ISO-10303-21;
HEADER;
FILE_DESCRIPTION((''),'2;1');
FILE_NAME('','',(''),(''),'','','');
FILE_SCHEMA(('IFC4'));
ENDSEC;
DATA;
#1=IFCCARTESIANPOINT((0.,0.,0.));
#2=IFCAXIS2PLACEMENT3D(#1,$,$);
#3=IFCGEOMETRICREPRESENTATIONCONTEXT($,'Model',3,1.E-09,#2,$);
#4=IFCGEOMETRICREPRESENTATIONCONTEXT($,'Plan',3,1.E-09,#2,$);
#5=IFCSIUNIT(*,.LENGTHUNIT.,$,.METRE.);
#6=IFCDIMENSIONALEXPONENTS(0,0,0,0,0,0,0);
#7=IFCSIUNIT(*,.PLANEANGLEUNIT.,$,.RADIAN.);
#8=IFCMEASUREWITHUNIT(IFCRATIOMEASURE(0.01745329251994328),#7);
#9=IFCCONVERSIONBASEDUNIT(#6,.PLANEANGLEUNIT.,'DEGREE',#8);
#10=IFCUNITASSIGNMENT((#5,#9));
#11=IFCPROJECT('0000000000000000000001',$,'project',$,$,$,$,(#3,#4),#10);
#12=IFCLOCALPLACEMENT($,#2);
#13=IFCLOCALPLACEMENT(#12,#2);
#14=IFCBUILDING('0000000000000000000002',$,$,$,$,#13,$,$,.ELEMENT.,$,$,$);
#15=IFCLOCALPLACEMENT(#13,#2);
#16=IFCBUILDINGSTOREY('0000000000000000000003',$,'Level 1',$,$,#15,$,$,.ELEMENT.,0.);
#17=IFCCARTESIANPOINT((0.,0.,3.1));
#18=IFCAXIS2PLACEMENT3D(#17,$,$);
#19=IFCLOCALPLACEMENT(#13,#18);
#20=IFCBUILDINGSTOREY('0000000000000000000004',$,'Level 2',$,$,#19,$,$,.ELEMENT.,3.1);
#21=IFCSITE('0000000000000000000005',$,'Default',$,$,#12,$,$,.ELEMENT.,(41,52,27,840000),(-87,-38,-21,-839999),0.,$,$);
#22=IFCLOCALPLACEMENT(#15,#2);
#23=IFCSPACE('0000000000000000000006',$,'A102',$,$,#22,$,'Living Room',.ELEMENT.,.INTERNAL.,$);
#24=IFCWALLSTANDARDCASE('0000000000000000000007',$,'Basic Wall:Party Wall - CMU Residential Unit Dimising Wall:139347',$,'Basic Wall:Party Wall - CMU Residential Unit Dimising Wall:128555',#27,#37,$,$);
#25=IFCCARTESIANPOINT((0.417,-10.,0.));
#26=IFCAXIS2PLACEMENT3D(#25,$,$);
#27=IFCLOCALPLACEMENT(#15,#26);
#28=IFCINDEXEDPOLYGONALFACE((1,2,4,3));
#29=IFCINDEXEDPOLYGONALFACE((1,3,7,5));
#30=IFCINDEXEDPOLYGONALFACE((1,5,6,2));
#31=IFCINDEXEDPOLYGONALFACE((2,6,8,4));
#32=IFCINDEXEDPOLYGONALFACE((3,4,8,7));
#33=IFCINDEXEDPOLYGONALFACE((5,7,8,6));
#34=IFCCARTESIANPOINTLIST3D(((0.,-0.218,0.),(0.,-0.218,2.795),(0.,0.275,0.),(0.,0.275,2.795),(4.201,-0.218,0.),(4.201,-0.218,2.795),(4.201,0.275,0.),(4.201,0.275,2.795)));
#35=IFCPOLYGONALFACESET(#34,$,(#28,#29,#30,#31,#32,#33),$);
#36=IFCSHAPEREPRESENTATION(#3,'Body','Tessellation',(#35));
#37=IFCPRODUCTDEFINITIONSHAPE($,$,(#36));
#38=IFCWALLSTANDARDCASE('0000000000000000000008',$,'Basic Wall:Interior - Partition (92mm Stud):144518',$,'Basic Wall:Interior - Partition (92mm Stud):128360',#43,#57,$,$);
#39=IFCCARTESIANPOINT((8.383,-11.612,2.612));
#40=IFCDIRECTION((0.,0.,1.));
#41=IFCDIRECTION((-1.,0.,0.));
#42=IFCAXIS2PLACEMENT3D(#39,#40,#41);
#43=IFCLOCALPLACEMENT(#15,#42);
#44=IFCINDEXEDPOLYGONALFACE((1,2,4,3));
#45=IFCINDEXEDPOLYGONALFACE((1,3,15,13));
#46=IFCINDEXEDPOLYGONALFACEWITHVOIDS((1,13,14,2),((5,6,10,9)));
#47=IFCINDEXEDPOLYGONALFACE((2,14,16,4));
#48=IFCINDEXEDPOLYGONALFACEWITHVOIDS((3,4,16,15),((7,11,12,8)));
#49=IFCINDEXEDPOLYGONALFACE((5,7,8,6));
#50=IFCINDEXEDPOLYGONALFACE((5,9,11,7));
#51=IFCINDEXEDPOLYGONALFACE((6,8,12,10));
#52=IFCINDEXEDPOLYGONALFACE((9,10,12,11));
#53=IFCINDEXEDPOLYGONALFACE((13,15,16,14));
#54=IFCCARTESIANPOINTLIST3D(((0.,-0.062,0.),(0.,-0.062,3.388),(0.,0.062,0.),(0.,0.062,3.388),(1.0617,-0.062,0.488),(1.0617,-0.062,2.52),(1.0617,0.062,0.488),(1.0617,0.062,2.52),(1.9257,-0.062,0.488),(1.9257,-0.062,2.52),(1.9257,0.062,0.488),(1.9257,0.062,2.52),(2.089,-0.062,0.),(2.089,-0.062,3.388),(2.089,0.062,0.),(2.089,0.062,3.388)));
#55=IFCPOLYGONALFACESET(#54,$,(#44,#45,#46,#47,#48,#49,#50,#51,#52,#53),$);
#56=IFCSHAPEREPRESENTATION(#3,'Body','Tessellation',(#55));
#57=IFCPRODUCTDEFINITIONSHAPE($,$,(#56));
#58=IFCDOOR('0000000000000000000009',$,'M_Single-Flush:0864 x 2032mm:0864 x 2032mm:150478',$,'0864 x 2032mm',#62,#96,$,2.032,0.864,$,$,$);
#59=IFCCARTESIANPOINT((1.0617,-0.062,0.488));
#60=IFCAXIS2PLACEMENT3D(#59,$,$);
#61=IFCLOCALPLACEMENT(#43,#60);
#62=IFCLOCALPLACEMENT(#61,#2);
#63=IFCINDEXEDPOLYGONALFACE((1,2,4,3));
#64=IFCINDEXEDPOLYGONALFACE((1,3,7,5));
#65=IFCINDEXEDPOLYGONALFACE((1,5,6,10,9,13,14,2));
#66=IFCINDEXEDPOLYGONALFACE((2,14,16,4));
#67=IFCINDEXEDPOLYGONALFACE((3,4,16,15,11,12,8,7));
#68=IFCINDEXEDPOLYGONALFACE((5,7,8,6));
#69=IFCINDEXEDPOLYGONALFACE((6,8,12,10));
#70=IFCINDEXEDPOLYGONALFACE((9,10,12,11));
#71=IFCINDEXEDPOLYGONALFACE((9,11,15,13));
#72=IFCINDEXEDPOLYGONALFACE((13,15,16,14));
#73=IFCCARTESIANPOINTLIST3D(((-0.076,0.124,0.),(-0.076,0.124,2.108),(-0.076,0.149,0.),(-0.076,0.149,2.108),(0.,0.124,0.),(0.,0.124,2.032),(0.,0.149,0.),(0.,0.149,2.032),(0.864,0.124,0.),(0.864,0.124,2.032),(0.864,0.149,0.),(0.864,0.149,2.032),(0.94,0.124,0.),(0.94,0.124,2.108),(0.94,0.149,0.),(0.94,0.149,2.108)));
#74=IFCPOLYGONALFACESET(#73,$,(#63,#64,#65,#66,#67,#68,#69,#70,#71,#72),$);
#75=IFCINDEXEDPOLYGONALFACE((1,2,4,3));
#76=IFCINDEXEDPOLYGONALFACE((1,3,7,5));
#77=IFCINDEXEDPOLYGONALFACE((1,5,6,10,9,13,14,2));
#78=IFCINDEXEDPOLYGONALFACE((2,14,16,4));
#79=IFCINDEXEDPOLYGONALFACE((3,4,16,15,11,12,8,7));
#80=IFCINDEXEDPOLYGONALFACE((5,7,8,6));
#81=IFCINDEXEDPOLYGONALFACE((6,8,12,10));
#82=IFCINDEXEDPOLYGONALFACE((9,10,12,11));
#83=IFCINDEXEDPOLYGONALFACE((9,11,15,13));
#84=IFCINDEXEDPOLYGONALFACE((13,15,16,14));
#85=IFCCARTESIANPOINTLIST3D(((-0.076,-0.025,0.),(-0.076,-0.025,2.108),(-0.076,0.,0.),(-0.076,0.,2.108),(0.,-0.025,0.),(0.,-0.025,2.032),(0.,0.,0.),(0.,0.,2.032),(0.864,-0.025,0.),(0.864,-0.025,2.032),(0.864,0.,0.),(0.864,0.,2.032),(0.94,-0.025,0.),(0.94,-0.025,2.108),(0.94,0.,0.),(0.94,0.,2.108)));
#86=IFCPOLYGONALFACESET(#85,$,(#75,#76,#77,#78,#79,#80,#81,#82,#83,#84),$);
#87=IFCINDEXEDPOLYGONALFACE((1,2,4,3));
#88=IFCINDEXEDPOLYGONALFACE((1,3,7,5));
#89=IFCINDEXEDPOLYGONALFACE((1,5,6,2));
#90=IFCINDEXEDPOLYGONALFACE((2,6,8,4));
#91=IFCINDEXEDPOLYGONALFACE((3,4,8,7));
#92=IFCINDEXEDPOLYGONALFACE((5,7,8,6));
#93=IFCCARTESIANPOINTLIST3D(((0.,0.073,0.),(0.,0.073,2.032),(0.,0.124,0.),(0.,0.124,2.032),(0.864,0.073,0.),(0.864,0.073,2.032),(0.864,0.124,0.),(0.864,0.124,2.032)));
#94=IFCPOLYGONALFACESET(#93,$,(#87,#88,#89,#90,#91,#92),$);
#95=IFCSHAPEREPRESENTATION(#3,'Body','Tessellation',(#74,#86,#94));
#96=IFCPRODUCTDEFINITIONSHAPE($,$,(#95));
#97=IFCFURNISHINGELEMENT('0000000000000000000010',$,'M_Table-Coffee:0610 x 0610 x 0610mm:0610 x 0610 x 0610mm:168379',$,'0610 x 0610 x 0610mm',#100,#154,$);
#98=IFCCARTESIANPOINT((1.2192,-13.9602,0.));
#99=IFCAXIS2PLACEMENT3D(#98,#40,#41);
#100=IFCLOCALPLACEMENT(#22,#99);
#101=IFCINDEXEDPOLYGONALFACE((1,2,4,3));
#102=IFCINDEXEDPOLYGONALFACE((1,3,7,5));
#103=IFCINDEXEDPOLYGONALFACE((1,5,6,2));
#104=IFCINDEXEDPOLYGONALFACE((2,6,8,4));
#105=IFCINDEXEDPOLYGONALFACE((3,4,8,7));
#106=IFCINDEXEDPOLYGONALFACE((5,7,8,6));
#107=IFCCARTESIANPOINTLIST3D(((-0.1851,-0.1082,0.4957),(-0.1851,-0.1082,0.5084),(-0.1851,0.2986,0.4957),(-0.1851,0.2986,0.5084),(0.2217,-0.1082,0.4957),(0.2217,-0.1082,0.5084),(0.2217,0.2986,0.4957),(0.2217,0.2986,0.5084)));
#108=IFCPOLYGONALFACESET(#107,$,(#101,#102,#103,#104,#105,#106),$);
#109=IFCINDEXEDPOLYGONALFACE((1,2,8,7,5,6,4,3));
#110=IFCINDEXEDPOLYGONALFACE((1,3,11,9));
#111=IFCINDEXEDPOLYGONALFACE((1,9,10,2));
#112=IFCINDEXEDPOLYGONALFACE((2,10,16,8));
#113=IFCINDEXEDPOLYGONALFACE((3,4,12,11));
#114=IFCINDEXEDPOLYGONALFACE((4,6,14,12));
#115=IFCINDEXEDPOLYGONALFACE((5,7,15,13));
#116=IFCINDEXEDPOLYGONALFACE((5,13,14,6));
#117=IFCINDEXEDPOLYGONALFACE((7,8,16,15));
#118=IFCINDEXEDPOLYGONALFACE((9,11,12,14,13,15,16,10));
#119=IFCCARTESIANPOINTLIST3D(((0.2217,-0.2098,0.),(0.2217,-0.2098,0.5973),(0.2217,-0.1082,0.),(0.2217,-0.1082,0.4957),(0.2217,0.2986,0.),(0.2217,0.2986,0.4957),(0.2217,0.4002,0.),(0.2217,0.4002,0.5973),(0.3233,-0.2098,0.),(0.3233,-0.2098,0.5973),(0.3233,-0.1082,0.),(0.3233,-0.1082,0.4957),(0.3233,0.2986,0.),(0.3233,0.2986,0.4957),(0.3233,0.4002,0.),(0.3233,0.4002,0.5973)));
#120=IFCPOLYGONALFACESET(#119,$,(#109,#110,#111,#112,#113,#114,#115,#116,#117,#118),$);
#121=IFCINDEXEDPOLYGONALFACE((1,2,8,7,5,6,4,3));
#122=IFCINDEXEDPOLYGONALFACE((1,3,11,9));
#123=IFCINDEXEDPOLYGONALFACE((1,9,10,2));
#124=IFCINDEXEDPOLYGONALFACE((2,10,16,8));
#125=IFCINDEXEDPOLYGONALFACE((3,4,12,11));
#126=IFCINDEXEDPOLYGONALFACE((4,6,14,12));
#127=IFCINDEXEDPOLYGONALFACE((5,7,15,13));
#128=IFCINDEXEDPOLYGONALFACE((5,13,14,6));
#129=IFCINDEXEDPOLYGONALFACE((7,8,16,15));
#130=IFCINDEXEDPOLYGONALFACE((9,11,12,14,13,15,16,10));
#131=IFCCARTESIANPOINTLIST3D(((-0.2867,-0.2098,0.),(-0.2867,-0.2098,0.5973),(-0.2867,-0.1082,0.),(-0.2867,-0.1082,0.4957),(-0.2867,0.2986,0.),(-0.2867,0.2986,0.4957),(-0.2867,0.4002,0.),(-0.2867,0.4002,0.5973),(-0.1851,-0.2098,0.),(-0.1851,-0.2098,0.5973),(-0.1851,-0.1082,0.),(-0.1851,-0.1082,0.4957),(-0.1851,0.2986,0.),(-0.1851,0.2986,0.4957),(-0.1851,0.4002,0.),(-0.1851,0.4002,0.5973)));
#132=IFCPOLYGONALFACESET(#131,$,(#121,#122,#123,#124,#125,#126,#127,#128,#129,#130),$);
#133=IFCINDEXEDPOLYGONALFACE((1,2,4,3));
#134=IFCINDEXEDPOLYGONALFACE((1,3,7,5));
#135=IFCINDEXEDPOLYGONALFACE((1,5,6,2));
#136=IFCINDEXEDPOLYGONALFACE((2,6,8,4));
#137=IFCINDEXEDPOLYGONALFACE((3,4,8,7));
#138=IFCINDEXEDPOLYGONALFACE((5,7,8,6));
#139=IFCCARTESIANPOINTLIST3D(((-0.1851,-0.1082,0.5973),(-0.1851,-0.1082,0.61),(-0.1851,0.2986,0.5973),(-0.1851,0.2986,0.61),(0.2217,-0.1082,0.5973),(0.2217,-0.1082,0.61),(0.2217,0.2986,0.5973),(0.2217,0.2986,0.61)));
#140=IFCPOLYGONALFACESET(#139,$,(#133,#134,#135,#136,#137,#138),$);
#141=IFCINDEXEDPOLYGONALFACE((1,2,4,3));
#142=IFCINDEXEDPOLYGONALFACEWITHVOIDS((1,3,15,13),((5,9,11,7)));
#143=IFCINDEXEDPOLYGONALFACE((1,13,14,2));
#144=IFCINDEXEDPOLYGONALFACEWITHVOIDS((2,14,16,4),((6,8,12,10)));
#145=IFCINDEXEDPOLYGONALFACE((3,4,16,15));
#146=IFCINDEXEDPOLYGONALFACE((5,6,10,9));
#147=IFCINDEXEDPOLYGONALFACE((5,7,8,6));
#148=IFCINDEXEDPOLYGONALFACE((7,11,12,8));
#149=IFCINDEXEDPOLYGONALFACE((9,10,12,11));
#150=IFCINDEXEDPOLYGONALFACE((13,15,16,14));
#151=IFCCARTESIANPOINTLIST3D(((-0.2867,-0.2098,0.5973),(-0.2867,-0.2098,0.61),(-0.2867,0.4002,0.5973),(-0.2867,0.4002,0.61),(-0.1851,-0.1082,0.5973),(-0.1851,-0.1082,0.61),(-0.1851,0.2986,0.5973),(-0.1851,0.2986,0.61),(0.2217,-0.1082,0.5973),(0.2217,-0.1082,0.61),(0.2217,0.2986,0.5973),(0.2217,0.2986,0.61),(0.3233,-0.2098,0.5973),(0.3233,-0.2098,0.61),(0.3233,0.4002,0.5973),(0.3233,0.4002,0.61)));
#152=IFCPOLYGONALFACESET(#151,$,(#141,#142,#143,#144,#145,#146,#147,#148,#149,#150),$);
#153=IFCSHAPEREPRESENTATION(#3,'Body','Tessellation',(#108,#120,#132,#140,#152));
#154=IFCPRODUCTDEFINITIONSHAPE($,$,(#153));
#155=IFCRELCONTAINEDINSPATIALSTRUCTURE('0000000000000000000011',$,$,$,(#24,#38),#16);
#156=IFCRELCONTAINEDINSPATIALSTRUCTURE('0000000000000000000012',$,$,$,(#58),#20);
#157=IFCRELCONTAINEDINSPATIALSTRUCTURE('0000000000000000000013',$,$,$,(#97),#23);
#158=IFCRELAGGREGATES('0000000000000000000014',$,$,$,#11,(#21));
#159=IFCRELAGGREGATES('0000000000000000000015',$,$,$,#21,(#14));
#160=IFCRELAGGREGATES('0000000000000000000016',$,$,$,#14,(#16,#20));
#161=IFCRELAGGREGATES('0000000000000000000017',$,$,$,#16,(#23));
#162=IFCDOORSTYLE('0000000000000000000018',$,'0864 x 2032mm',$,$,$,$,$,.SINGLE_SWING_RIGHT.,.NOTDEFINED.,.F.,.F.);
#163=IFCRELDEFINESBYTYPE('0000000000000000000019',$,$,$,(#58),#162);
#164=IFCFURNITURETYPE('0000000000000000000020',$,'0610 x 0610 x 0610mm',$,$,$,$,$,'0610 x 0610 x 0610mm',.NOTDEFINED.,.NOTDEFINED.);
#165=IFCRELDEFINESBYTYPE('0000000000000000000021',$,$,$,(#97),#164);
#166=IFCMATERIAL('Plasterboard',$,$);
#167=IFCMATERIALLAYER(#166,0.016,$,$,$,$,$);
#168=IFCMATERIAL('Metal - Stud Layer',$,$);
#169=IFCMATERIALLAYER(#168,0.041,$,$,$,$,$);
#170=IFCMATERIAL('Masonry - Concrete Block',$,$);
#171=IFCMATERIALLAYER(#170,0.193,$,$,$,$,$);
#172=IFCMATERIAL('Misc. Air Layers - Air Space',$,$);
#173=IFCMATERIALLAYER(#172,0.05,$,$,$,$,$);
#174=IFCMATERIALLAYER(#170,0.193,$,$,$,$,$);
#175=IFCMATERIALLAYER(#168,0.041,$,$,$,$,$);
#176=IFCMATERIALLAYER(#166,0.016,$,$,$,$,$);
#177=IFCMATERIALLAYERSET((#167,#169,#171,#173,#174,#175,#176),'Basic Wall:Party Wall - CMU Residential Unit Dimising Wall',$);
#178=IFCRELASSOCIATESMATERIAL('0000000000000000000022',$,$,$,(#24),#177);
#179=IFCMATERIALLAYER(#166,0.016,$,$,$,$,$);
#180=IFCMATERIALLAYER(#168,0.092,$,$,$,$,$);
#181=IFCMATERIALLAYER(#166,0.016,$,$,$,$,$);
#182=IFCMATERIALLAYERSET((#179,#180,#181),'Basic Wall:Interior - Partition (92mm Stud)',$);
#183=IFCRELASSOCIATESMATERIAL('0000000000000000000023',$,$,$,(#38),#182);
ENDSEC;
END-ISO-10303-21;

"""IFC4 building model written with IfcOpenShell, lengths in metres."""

from ifc_helpers import new_model, entity, si_unit, converted_unit, frame, frame_2d, origin, origin_2d_with_axis, place, context, project, spatial, polyline, rectangle, outline, extrude, clip, bounded_halfspace, source, transform, mapped, material, layer, layer_set, layer_usage, type_object, type_shapes, element, fill, save


model = new_model("IFC4")

# Units and contexts
model_context = context("Model", 3, precision=1e-09, world=origin())
plan_context = context("Plan", 3, precision=1e-09, world=origin())
ifc_project = project(units=[si_unit("LENGTHUNIT", "METRE"), converted_unit("PLANEANGLEUNIT", "DEGREE", entity("IfcRatioMeasure", 0.01745329251994328), si_unit("PLANEANGLEUNIT", "RADIAN"), dimensions=[0, 0, 0, 0, 0, 0, 0])], contexts=[model_context, plan_context])

# Site, building, storey
site_placement = place(None, origin())
site = spatial("IfcSite", under=ifc_project, at=site_placement, Name="Default", CompositionType="ELEMENT", RefLatitude=(41, 52, 27, 840000), RefLongitude=(-87, -38, -21, -839999), RefElevation=0.0)
building_placement = place(site_placement, origin())
building = spatial("IfcBuilding", under=site, at=building_placement, CompositionType="ELEMENT")
storey_1_placement = place(building_placement, origin())
storey_1 = spatial("IfcBuildingStorey", under=building, at=storey_1_placement, Name="Level 1", CompositionType="ELEMENT", Elevation=0.0)

# Shared definitions
ifc_material_1 = material(Name="Misc. Air Layers - Air Space")
ifc_material_2 = material(Name="Masonry - Concrete Block")
ifc_material_3 = material(Name="Metal - Stud Layer")
ifc_material_4 = material(Name="Plasterboard")

# Wall
ifc_layer_1 = layer(ifc_material_4, 0.016)
ifc_layer_2 = layer(ifc_material_3, 0.041)
ifc_layer_3 = layer(ifc_material_2, 0.193)
ifc_layer_4 = layer(ifc_material_1, 0.05)
ifc_layer_5 = layer(ifc_material_2, 0.193)
ifc_layer_6 = layer(ifc_material_3, 0.041)
ifc_layer_7 = layer(ifc_material_4, 0.016)
ifc_layer_set_1 = layer_set([ifc_layer_1, ifc_layer_2, ifc_layer_3, ifc_layer_4, ifc_layer_5, ifc_layer_6, ifc_layer_7], Name="Basic Wall:Party Wall - CMU Residential Unit Dimising Wall")
ifc_layer_usage_1 = layer_usage(ifc_layer_set_1, "AXIS2", "NEGATIVE", 0.275)
wall_1_placement = place(storey_1_placement, frame((0.417, -10.0, 0.0)))
element("IfcWallStandardCase", 1, at=wall_1_placement, inside=storey_1, material=ifc_layer_usage_1, Name="Basic Wall:Party Wall - CMU Residential Unit Dimising Wall:139347", ObjectType="Basic Wall:Party Wall - CMU Residential Unit Dimising Wall:128555", context=model_context, shape_type="Clipping", body=[
    clip(clip(extrude(rectangle(XDim=4.201, YDim=0.55, at=frame_2d((2.1005, 0.0), x_axis=(-1.0, 0.0))), origin(), (0.0, 0.0, 1.0), 2.795), bounded_halfspace(frame((0.0, -0.218, 0.0), z_axis=(0.0, 1.0, 0.0), x_axis=(-1.0, 0.0, 0.0)), True, frame((0.0, -0.218, 0.0), z_axis=(0.0, 1.0, 0.0), x_axis=(-1.0, 0.0, 0.0)), polyline([(0.0, 0.0), (0.0, 2.795), (-4.201, 2.795), (-4.201, 0.0), (0.0, 0.0)]))), bounded_halfspace(frame((4.201, 0.275, 0.0), z_axis=(-1.0, 0.0, 0.0), x_axis=(0.0, -1.0, 0.0)), True, frame((4.201, 0.275, 0.0), z_axis=(-1.0, 0.0, 0.0), x_axis=(0.0, -1.0, 0.0)), polyline([(0.0, 0.0), (0.493, 0.0), (0.493, 2.795), (0.0, 2.795), (0.0, 0.0)]))),
])

# Shared definitions
ifc_layer_8 = layer(ifc_material_4, 0.016)
ifc_layer_9 = layer(ifc_material_3, 0.092)
ifc_layer_10 = layer(ifc_material_4, 0.016)
ifc_layer_set_2 = layer_set([ifc_layer_8, ifc_layer_9, ifc_layer_10], Name="Basic Wall:Interior - Partition (92mm Stud)")

# Wall, opening
ifc_layer_usage_2 = layer_usage(ifc_layer_set_2, "AXIS2", "NEGATIVE", 0.062)
wall_2_placement = place(storey_1_placement, frame((8.383, -11.612, 2.612), z_axis=(0.0, 0.0, 1.0), x_axis=(-1.0, 0.0, 0.0)))
wall_2 = element("IfcWallStandardCase", 2, at=wall_2_placement, inside=storey_1, material=ifc_layer_usage_2, Name="Basic Wall:Interior - Partition (92mm Stud):144518", ObjectType="Basic Wall:Interior - Partition (92mm Stud):128360", context=model_context, shape_type="SweptSolid", body=[
    extrude(rectangle(XDim=2.089, YDim=0.124, at=frame_2d((1.0445, 0.0), x_axis=(-1.0, 0.0))), origin(), (0.0, 0.0, 1.0), 3.388),
])
opening_1_placement = place(wall_2_placement, frame((1.0617, -0.062, 0.488)))
opening_1 = element("IfcOpeningElement", 3, at=opening_1_placement, cuts=wall_2, ObjectType="Opening", context=model_context, shape_type="SweptSolid", body=[
    extrude(rectangle(XDim=0.864, YDim=2.032, at=frame_2d((1.016, 0.432), x_axis=(0.0, 1.0))), frame((0.0, 0.0, 0.0), z_axis=(0.0, 1.0, 0.0), x_axis=(0.0, 0.0, 1.0)), (0.0, 0.0, 1.0), 0.124),
])

# Shared definitions
storey_2_placement = place(building_placement, frame((0.0, 0.0, 3.1)))
storey_2 = spatial("IfcBuildingStorey", under=building, at=storey_2_placement, Name="Level 2", CompositionType="ELEMENT", Elevation=3.1)

# Door
door_style_1 = type_object("IfcDoorStyle", Name="0864 x 2032mm", ConstructionType="NOTDEFINED", OperationType="SINGLE_SWING_RIGHT", ParameterTakesPrecedence=False, Sizeable=False)
shared_shape_1 = source(origin(), model_context, "Body", "SweptSolid", [
    extrude(outline(polyline([(-0.508, -1.073), (0.508, -1.073), (0.508, 1.035), (0.432, 1.035), (0.432, -0.997), (-0.432, -0.997), (-0.432, 1.035), (-0.508, 1.035), (-0.508, -1.073)])), frame((0.432, 0.124, 1.035), z_axis=(0.0, 1.0, 0.0), x_axis=(1.0, 0.0, 0.0)), (0.0, 0.0, 1.0), 0.025),
    extrude(outline(polyline([(-1.073, -0.508), (1.035, -0.508), (1.035, -0.432), (-0.997, -0.432), (-0.997, 0.432), (1.035, 0.432), (1.035, 0.508), (-1.073, 0.508), (-1.073, -0.508)])), frame((0.432, -0.025, 1.035), z_axis=(0.0, 1.0, 0.0), x_axis=(0.0, 0.0, -1.0)), (0.0, 0.0, 1.0), 0.025),
    extrude(rectangle(XDim=0.051, YDim=0.864, at=origin_2d_with_axis()), frame((0.432, 0.0985, 0.0), z_axis=(0.0, 0.0, 1.0), x_axis=(0.0, 1.0, 0.0)), (0.0, 0.0, 1.0), 2.032),
])
type_shapes(door_style_1, [shared_shape_1])
door_1_placement = place(opening_1_placement, origin())
door_1 = element("IfcDoor", 4, at=door_1_placement, inside=storey_2, type_object=door_style_1, Name="M_Single-Flush:0864 x 2032mm:0864 x 2032mm:150478", ObjectType="0864 x 2032mm", OverallHeight=2.032, OverallWidth=0.864, context=model_context, shape_type="MappedRepresentation", body=[
    mapped(shared_shape_1, transform((0.0, 0.0, 0.0), scale=1.0)),
])
fill(opening_1, door_1)

# Shared definitions
space_1_placement = place(storey_1_placement, origin())
space_1 = spatial("IfcSpace", under=storey_1, at=space_1_placement, Name="A102", LongName="Living Room", CompositionType="ELEMENT", PredefinedType="INTERNAL")

# Furnishing element
furniture_type_1 = type_object("IfcFurnitureType", Name="0610 x 0610 x 0610mm", ElementType="0610 x 0610 x 0610mm", AssemblyPlace="NOTDEFINED")
shared_shape_2 = source(origin(), model_context, "Body", "SweptSolid", [
    extrude(rectangle(XDim=0.4068, YDim=0.4068, at=origin_2d_with_axis()), frame((0.0183, 0.0952, 0.4957), z_axis=(0.0, 0.0, 1.0), x_axis=(-1.0, 0.0, 0.0)), (0.0, 0.0, 1.0), 0.0127),
    extrude(outline(polyline([(-0.2732, -0.305), (0.324, -0.305), (0.324, 0.305), (-0.2732, 0.305), (-0.2732, 0.2034), (0.2225, 0.2034), (0.2225, -0.2034), (-0.2732, -0.2034), (-0.2732, -0.305)])), frame((0.2217, 0.0952, 0.2732), z_axis=(1.0, 0.0, 0.0), x_axis=(0.0, 0.0, 1.0)), (0.0, 0.0, 1.0), 0.1016),
    extrude(outline(polyline([(-0.305, -0.3241), (0.305, -0.3241), (0.305, 0.2733), (0.2034, 0.2733), (0.2034, -0.2224), (-0.2034, -0.2224), (-0.2034, 0.2733), (-0.305, 0.2733), (-0.305, -0.3241)])), frame((-0.2867, 0.0952, 0.2733), z_axis=(1.0, 0.0, 0.0), x_axis=(0.0, -1.0, 0.0)), (0.0, 0.0, 1.0), 0.1016),
    extrude(rectangle(XDim=0.4068, YDim=0.4068, at=origin_2d_with_axis()), frame((0.0183, 0.0952, 0.5973), z_axis=(0.0, 0.0, 1.0), x_axis=(-1.0, 0.0, 0.0)), (0.0, 0.0, 1.0), 0.0127),
    extrude(outline(polyline([(-0.305, -0.305), (0.305, -0.305), (0.305, 0.305), (-0.305, 0.305), (-0.305, -0.305)]), holes=[polyline([(-0.2034, -0.2034), (-0.2034, 0.2034), (0.2034, 0.2034), (0.2034, -0.2034), (-0.2034, -0.2034)])]), frame((0.0183, 0.0952, 0.5973), z_axis=(0.0, 0.0, 1.0), x_axis=(-1.0, 0.0, 0.0)), (0.0, 0.0, 1.0), 0.0127),
])
type_shapes(furniture_type_1, [shared_shape_2])
for number, where, z_axis, x_axis, name in (
    (5, (1.2192, -13.9602, 0.0), (0.0, 0.0, 1.0), (-1.0, 0.0, 0.0), "M_Table-Coffee:0610 x 0610 x 0610mm:0610 x 0610 x 0610mm:168379"),
):
    element("IfcFurnishingElement", number, at=place(space_1_placement, frame(where, z_axis=z_axis, x_axis=x_axis)), inside=space_1, type_object=furniture_type_1, Name=name, ObjectType="0610 x 0610 x 0610mm", context=model_context, shape_type="MappedRepresentation", body=[
        mapped(shared_shape_2, transform((0.0, 0.0, 0.0), scale=1.0)),
    ])

save(model, "model.ifc")
